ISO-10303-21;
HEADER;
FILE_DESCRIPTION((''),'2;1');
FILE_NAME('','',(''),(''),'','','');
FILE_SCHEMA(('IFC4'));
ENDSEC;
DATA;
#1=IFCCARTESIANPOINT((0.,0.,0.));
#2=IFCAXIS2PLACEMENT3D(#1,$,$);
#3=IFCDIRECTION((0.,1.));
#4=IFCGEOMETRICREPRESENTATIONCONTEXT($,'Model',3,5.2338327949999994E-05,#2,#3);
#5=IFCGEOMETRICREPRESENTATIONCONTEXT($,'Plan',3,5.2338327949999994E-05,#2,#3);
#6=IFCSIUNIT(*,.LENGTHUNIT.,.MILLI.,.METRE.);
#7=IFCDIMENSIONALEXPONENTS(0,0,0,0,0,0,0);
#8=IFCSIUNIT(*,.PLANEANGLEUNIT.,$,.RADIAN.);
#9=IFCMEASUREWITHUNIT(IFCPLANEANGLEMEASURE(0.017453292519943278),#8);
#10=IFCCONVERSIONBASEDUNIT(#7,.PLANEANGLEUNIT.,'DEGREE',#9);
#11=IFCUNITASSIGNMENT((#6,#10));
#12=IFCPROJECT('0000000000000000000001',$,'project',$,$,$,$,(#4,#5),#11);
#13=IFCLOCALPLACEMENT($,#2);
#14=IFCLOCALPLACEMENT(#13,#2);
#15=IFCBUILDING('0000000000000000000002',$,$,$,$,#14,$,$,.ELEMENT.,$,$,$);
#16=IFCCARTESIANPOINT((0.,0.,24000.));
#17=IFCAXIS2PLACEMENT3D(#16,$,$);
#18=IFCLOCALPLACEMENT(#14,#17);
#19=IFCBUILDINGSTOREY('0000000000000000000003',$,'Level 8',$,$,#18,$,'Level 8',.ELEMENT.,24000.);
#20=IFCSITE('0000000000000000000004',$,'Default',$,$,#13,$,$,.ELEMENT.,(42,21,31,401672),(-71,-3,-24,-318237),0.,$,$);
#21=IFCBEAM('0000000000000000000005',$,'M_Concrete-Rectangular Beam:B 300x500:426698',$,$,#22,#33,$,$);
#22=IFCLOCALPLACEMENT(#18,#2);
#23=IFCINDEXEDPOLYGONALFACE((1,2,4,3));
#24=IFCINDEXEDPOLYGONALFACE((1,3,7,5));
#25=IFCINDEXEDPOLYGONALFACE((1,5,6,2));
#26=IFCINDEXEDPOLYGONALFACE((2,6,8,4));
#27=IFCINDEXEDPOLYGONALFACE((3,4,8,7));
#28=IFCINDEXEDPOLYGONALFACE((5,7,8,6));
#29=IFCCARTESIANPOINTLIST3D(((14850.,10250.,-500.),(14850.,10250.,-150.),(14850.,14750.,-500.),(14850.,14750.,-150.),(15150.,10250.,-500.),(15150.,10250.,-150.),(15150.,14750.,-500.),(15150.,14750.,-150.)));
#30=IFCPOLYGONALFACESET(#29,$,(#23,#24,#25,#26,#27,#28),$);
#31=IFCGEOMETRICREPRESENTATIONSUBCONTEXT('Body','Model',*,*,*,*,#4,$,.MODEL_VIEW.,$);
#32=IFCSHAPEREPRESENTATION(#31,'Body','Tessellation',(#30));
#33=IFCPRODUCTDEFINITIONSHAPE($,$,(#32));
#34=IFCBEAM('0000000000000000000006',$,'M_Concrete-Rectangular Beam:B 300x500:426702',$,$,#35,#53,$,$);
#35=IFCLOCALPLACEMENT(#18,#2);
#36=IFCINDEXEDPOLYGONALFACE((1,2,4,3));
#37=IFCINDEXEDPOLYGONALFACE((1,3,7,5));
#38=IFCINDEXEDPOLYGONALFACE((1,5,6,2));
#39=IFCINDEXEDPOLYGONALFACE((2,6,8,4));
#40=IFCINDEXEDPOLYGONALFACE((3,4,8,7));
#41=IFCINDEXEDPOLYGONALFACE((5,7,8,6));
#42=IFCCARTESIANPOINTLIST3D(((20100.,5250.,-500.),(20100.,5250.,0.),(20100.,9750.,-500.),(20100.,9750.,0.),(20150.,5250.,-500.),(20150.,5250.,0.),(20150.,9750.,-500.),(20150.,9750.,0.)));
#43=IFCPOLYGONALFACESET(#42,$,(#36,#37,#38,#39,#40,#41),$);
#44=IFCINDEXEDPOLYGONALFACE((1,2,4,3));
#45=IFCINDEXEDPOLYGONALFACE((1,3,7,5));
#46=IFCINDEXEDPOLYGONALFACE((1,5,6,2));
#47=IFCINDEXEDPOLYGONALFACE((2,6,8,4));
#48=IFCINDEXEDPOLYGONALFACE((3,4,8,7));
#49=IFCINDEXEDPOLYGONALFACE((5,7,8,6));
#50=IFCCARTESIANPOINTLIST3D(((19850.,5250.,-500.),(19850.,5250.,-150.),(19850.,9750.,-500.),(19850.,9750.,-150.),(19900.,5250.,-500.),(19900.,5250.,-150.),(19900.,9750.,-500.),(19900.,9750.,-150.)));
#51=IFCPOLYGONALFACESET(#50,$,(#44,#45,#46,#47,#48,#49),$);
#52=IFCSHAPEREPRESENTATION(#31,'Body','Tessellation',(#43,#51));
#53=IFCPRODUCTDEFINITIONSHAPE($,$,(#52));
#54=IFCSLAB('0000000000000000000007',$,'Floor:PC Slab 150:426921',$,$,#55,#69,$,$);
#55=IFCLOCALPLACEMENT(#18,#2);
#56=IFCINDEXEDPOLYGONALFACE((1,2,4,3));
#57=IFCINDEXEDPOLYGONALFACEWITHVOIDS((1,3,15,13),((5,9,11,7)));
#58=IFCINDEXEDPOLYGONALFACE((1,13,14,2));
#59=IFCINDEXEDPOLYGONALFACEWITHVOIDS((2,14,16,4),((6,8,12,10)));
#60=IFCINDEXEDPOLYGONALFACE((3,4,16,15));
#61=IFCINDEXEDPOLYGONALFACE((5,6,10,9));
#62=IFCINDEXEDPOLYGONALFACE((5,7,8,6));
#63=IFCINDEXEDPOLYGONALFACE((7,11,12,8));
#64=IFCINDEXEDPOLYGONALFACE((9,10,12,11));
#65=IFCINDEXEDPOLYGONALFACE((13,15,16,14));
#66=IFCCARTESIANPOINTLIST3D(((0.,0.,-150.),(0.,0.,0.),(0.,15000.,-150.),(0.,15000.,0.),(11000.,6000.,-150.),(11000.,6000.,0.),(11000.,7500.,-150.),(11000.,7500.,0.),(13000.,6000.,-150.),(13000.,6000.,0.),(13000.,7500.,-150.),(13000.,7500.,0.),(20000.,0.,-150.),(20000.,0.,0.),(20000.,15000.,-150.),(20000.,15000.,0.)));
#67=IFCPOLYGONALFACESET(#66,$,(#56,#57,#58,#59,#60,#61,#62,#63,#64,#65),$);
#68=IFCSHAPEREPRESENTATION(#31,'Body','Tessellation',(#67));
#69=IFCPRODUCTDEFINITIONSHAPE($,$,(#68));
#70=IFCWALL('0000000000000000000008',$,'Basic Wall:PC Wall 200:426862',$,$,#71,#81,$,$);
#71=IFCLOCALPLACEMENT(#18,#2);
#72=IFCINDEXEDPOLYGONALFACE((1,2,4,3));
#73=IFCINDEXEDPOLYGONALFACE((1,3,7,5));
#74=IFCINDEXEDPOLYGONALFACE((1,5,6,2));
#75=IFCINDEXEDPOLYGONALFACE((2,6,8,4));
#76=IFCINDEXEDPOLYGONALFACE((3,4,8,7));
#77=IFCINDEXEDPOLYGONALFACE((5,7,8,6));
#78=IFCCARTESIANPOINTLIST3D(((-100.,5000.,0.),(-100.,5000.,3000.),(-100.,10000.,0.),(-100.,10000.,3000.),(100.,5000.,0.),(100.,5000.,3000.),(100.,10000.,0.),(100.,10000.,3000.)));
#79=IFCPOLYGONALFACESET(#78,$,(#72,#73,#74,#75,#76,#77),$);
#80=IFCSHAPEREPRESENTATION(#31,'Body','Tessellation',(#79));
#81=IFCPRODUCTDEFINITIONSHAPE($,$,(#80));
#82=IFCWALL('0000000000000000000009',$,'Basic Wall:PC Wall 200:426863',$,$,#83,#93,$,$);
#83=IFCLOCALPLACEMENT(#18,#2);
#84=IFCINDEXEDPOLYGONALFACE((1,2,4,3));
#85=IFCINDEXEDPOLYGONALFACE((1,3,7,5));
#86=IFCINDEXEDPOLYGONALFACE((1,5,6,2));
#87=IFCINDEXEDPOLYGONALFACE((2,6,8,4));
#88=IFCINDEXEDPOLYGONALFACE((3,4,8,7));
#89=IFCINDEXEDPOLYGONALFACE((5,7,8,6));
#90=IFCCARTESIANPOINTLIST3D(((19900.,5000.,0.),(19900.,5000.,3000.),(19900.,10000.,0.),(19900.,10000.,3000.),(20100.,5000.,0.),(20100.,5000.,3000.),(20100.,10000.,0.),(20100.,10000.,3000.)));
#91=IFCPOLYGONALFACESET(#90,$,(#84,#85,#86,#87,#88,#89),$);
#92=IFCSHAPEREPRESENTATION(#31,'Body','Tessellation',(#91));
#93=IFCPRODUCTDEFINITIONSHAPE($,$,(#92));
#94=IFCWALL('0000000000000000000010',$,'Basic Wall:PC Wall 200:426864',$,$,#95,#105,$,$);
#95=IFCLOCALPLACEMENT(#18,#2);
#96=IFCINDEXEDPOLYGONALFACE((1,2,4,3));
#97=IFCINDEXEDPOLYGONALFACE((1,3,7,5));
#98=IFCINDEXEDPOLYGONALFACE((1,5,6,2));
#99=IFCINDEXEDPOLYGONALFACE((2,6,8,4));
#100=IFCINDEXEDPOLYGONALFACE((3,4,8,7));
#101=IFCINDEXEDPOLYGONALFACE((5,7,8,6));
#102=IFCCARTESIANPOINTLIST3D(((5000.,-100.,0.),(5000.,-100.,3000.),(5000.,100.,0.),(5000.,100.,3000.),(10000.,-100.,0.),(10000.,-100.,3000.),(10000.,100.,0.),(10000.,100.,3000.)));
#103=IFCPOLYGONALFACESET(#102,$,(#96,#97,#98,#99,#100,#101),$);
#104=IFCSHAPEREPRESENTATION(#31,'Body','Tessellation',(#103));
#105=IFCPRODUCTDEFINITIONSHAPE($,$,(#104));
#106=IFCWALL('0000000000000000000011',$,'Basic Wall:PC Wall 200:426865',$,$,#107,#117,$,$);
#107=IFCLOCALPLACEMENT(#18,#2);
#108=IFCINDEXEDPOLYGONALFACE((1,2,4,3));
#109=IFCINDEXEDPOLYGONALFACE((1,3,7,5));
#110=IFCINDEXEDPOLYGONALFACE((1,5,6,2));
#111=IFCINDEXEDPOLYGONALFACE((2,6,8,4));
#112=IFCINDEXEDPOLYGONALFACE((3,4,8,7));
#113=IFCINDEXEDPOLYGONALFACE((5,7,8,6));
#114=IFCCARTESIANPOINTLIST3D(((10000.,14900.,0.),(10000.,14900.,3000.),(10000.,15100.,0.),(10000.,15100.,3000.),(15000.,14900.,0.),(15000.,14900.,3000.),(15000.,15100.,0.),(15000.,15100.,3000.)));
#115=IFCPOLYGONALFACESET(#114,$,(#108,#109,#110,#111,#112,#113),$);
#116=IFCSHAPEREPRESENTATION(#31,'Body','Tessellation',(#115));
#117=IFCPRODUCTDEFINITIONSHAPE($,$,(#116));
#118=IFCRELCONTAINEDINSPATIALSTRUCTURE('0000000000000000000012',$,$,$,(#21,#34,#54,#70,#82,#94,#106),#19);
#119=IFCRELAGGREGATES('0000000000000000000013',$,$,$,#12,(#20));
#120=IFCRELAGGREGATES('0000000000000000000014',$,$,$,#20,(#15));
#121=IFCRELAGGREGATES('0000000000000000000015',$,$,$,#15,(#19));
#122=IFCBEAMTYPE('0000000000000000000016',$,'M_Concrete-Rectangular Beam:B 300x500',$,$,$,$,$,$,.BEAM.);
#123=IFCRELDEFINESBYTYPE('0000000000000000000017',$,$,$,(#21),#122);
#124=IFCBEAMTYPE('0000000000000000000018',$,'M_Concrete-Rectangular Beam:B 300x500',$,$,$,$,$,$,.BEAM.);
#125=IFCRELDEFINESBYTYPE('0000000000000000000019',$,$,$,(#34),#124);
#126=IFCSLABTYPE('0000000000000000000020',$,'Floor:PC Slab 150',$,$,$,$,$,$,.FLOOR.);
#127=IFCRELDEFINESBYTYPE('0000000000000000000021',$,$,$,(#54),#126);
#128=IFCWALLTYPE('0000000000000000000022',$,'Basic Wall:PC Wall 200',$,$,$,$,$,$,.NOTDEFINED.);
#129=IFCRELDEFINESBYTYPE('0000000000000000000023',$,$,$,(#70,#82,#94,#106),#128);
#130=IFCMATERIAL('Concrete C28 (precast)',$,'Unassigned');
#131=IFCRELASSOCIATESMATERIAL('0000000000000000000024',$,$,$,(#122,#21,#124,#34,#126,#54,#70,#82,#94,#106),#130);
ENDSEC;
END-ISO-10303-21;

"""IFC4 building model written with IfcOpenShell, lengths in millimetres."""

from ifc_helpers import new_model, entity, si_unit, converted_unit, direction, frame, origin, place, context, subcontext, project, spatial, indexed_curve, outline, extrude, source, transform, mapped, material, type_object, type_shapes, element, save


model = new_model("IFC4")

# Units and contexts
model_context = context("Model", 3, precision=5.2338327949999994e-05, world=origin(), true_north=direction((0.0, 1.0)))
plan_context = context("Plan", 3, precision=5.2338327949999994e-05, world=origin(), true_north=direction((0.0, 1.0)))
body_context = subcontext(model_context, "Body", "Model", "MODEL_VIEW")
ifc_project = project(units=[si_unit("LENGTHUNIT", "METRE", prefix="MILLI"), converted_unit("PLANEANGLEUNIT", "DEGREE", entity("IfcPlaneAngleMeasure", 0.017453292519943278), si_unit("PLANEANGLEUNIT", "RADIAN"), dimensions=[0, 0, 0, 0, 0, 0, 0])], contexts=[model_context, plan_context])

# Site, building, storey
site_placement = place(None, origin())
site = spatial("IfcSite", under=ifc_project, at=site_placement, Name="Default", CompositionType="ELEMENT", RefLatitude=(42, 21, 31, 401672), RefLongitude=(-71, -3, -24, -318237), RefElevation=0.0)
building_placement = place(site_placement, origin())
building = spatial("IfcBuilding", under=site, at=building_placement, CompositionType="ELEMENT")
storey_placement = place(building_placement, frame((0.0, 0.0, 24000.0)))
storey = spatial("IfcBuildingStorey", under=building, at=storey_placement, Name="Level 8", LongName="Level 8", CompositionType="ELEMENT", Elevation=24000.0)

# Beams
ifc_material = material(Name="Concrete C28 (precast)", Category="Unassigned")
beam_type_1 = type_object("IfcBeamType", Name="M_Concrete-Rectangular Beam:B 300x500", PredefinedType="BEAM", material=ifc_material)
shared_shape_1 = source(origin(), body_context, "Body", "SweptSolid", [
    extrude(outline(indexed_curve([(-150.0, -175.0), (150.0, -175.0), (150.0, 175.0), (-150.0, 175.0), (-150.0, -175.0)], self_intersect=False)), frame((15000.0, 10250.0, 23675.0), z_axis=(0.0, 1.0, 0.0), x_axis=(-1.0, 0.0, 0.0)), (0.0, 0.0, 1.0), 4500.0),
])
type_shapes(beam_type_1, [shared_shape_1])
beam_1_placement = place(storey_placement, frame((0.0, 0.0, -24000.0)))
element("IfcBeam", 1, at=beam_1_placement, inside=storey, type_object=beam_type_1, material=ifc_material, Name="M_Concrete-Rectangular Beam:B 300x500:426698", context=body_context, shape_type="MappedRepresentation", body=[
    mapped(shared_shape_1, transform((0.0, 0.0, 0.0), scale=1.0)),
])
beam_type_2 = type_object("IfcBeamType", Name="M_Concrete-Rectangular Beam:B 300x500", PredefinedType="BEAM", material=ifc_material)
shared_shape_2 = source(origin(), body_context, "Body", "SweptSolid", [
    extrude(outline(indexed_curve([(-25.0, -250.0), (25.0, -250.0), (25.0, 250.0), (-25.0, 250.0), (-25.0, -250.0)], self_intersect=False)), frame((20125.0, 5250.0, 23750.0), z_axis=(0.0, 1.0, 0.0), x_axis=(-1.0, 0.0, 0.0)), (0.0, 0.0, 1.0), 4500.0),
    extrude(outline(indexed_curve([(-25.0, -175.0), (25.0, -175.0), (25.0, 175.0), (-25.0, 175.0), (-25.0, -175.0)], self_intersect=False)), frame((19875.0, 5250.0, 23675.0), z_axis=(0.0, 1.0, 0.0), x_axis=(-1.0, 0.0, 0.0)), (0.0, 0.0, 1.0), 4500.0),
])
type_shapes(beam_type_2, [shared_shape_2])
beam_2_placement = place(storey_placement, frame((0.0, 0.0, -24000.0)))
element("IfcBeam", 2, at=beam_2_placement, inside=storey, type_object=beam_type_2, material=ifc_material, Name="M_Concrete-Rectangular Beam:B 300x500:426702", context=body_context, shape_type="MappedRepresentation", body=[
    mapped(shared_shape_2, transform((0.0, 0.0, 0.0), scale=1.0)),
])

# Slab, opening
slab_type = type_object("IfcSlabType", Name="Floor:PC Slab 150", PredefinedType="FLOOR", material=ifc_material)
slab_placement = place(storey_placement, origin())
slab = element("IfcSlab", 3, at=slab_placement, inside=storey, type_object=slab_type, material=ifc_material, Name="Floor:PC Slab 150:426921", context=body_context, shape_type="SweptSolid", body=[
    extrude(outline(indexed_curve([(-7500.0, -10000.0), (7500.0, -10000.0), (7500.0, 10000.0), (-7500.0, 10000.0), (-7500.0, -10000.0)], self_intersect=False), holes=[indexed_curve([(-1500.0, -3000.0), (-1500.0, -1000.0), (0.0, -1000.0), (0.0, -3000.0), (-1500.0, -3000.0)], self_intersect=False)]), frame((10000.0, 7500.0, -150.0), z_axis=(0.0, 0.0, 1.0), x_axis=(0.0, 1.0, 0.0)), (0.0, 0.0, 1.0), 150.0),
])
opening_placement = place(slab_placement, origin())
element("IfcOpeningElement", 4, at=opening_placement, cuts=slab, PredefinedType="OPENING", context=body_context, shape_type="SweptSolid", body=[
    extrude(outline(indexed_curve([(13000.0, 6000.0), (13000.0, 7500.0), (11000.0, 7500.0), (11000.0, 6000.0), (13000.0, 6000.0)], self_intersect=False)), frame((0.0, 0.0, -24000.0)), (0.0, 0.0, 1.0), 20000.0),
])

# Walls
wall_type = type_object("IfcWallType", Name="Basic Wall:PC Wall 200", PredefinedType="NOTDEFINED")
wall_1_placement = place(storey_placement, frame((0.0, 5000.0, 0.0), z_axis=(0.0, 0.0, 1.0), x_axis=(0.0, 1.0, 0.0)))
element("IfcWall", 5, at=wall_1_placement, inside=storey, type_object=wall_type, material=ifc_material, Name="Basic Wall:PC Wall 200:426862", context=body_context, shape_type="SweptSolid", body=[
    extrude(outline(indexed_curve([(5000.0, 100.0), (0.0, 100.0), (0.0, -100.0), (5000.0, -100.0), (5000.0, 100.0)], self_intersect=False)), origin(), (0.0, 0.0, 1.0), 3000.0),
])
wall_2_placement = place(storey_placement, frame((20000.0, 5000.0, 0.0), z_axis=(0.0, 0.0, 1.0), x_axis=(0.0, 1.0, 0.0)))
element("IfcWall", 6, at=wall_2_placement, inside=storey, type_object=wall_type, material=ifc_material, Name="Basic Wall:PC Wall 200:426863", context=body_context, shape_type="SweptSolid", body=[
    extrude(outline(indexed_curve([(5000.0, 100.0), (0.0, 100.0), (0.0, -100.0), (5000.0, -100.0), (5000.0, 100.0)], self_intersect=False)), origin(), (0.0, 0.0, 1.0), 3000.0),
])
wall_3_placement = place(storey_placement, frame((5000.0, 0.0, 0.0)))
element("IfcWall", 7, at=wall_3_placement, inside=storey, type_object=wall_type, material=ifc_material, Name="Basic Wall:PC Wall 200:426864", context=body_context, shape_type="SweptSolid", body=[
    extrude(outline(indexed_curve([(5000.0, 100.0), (0.0, 100.0), (0.0, -100.0), (5000.0, -100.0), (5000.0, 100.0)], self_intersect=False)), origin(), (0.0, 0.0, 1.0), 3000.0),
])
wall_4_placement = place(storey_placement, frame((10000.0, 15000.0, 0.0)))
element("IfcWall", 8, at=wall_4_placement, inside=storey, type_object=wall_type, material=ifc_material, Name="Basic Wall:PC Wall 200:426865", context=body_context, shape_type="SweptSolid", body=[
    extrude(outline(indexed_curve([(5000.0, 100.0), (0.0, 100.0), (0.0, -100.0), (5000.0, -100.0), (5000.0, 100.0)], self_intersect=False)), origin(), (0.0, 0.0, 1.0), 3000.0),
])

save(model, "model.ifc")
